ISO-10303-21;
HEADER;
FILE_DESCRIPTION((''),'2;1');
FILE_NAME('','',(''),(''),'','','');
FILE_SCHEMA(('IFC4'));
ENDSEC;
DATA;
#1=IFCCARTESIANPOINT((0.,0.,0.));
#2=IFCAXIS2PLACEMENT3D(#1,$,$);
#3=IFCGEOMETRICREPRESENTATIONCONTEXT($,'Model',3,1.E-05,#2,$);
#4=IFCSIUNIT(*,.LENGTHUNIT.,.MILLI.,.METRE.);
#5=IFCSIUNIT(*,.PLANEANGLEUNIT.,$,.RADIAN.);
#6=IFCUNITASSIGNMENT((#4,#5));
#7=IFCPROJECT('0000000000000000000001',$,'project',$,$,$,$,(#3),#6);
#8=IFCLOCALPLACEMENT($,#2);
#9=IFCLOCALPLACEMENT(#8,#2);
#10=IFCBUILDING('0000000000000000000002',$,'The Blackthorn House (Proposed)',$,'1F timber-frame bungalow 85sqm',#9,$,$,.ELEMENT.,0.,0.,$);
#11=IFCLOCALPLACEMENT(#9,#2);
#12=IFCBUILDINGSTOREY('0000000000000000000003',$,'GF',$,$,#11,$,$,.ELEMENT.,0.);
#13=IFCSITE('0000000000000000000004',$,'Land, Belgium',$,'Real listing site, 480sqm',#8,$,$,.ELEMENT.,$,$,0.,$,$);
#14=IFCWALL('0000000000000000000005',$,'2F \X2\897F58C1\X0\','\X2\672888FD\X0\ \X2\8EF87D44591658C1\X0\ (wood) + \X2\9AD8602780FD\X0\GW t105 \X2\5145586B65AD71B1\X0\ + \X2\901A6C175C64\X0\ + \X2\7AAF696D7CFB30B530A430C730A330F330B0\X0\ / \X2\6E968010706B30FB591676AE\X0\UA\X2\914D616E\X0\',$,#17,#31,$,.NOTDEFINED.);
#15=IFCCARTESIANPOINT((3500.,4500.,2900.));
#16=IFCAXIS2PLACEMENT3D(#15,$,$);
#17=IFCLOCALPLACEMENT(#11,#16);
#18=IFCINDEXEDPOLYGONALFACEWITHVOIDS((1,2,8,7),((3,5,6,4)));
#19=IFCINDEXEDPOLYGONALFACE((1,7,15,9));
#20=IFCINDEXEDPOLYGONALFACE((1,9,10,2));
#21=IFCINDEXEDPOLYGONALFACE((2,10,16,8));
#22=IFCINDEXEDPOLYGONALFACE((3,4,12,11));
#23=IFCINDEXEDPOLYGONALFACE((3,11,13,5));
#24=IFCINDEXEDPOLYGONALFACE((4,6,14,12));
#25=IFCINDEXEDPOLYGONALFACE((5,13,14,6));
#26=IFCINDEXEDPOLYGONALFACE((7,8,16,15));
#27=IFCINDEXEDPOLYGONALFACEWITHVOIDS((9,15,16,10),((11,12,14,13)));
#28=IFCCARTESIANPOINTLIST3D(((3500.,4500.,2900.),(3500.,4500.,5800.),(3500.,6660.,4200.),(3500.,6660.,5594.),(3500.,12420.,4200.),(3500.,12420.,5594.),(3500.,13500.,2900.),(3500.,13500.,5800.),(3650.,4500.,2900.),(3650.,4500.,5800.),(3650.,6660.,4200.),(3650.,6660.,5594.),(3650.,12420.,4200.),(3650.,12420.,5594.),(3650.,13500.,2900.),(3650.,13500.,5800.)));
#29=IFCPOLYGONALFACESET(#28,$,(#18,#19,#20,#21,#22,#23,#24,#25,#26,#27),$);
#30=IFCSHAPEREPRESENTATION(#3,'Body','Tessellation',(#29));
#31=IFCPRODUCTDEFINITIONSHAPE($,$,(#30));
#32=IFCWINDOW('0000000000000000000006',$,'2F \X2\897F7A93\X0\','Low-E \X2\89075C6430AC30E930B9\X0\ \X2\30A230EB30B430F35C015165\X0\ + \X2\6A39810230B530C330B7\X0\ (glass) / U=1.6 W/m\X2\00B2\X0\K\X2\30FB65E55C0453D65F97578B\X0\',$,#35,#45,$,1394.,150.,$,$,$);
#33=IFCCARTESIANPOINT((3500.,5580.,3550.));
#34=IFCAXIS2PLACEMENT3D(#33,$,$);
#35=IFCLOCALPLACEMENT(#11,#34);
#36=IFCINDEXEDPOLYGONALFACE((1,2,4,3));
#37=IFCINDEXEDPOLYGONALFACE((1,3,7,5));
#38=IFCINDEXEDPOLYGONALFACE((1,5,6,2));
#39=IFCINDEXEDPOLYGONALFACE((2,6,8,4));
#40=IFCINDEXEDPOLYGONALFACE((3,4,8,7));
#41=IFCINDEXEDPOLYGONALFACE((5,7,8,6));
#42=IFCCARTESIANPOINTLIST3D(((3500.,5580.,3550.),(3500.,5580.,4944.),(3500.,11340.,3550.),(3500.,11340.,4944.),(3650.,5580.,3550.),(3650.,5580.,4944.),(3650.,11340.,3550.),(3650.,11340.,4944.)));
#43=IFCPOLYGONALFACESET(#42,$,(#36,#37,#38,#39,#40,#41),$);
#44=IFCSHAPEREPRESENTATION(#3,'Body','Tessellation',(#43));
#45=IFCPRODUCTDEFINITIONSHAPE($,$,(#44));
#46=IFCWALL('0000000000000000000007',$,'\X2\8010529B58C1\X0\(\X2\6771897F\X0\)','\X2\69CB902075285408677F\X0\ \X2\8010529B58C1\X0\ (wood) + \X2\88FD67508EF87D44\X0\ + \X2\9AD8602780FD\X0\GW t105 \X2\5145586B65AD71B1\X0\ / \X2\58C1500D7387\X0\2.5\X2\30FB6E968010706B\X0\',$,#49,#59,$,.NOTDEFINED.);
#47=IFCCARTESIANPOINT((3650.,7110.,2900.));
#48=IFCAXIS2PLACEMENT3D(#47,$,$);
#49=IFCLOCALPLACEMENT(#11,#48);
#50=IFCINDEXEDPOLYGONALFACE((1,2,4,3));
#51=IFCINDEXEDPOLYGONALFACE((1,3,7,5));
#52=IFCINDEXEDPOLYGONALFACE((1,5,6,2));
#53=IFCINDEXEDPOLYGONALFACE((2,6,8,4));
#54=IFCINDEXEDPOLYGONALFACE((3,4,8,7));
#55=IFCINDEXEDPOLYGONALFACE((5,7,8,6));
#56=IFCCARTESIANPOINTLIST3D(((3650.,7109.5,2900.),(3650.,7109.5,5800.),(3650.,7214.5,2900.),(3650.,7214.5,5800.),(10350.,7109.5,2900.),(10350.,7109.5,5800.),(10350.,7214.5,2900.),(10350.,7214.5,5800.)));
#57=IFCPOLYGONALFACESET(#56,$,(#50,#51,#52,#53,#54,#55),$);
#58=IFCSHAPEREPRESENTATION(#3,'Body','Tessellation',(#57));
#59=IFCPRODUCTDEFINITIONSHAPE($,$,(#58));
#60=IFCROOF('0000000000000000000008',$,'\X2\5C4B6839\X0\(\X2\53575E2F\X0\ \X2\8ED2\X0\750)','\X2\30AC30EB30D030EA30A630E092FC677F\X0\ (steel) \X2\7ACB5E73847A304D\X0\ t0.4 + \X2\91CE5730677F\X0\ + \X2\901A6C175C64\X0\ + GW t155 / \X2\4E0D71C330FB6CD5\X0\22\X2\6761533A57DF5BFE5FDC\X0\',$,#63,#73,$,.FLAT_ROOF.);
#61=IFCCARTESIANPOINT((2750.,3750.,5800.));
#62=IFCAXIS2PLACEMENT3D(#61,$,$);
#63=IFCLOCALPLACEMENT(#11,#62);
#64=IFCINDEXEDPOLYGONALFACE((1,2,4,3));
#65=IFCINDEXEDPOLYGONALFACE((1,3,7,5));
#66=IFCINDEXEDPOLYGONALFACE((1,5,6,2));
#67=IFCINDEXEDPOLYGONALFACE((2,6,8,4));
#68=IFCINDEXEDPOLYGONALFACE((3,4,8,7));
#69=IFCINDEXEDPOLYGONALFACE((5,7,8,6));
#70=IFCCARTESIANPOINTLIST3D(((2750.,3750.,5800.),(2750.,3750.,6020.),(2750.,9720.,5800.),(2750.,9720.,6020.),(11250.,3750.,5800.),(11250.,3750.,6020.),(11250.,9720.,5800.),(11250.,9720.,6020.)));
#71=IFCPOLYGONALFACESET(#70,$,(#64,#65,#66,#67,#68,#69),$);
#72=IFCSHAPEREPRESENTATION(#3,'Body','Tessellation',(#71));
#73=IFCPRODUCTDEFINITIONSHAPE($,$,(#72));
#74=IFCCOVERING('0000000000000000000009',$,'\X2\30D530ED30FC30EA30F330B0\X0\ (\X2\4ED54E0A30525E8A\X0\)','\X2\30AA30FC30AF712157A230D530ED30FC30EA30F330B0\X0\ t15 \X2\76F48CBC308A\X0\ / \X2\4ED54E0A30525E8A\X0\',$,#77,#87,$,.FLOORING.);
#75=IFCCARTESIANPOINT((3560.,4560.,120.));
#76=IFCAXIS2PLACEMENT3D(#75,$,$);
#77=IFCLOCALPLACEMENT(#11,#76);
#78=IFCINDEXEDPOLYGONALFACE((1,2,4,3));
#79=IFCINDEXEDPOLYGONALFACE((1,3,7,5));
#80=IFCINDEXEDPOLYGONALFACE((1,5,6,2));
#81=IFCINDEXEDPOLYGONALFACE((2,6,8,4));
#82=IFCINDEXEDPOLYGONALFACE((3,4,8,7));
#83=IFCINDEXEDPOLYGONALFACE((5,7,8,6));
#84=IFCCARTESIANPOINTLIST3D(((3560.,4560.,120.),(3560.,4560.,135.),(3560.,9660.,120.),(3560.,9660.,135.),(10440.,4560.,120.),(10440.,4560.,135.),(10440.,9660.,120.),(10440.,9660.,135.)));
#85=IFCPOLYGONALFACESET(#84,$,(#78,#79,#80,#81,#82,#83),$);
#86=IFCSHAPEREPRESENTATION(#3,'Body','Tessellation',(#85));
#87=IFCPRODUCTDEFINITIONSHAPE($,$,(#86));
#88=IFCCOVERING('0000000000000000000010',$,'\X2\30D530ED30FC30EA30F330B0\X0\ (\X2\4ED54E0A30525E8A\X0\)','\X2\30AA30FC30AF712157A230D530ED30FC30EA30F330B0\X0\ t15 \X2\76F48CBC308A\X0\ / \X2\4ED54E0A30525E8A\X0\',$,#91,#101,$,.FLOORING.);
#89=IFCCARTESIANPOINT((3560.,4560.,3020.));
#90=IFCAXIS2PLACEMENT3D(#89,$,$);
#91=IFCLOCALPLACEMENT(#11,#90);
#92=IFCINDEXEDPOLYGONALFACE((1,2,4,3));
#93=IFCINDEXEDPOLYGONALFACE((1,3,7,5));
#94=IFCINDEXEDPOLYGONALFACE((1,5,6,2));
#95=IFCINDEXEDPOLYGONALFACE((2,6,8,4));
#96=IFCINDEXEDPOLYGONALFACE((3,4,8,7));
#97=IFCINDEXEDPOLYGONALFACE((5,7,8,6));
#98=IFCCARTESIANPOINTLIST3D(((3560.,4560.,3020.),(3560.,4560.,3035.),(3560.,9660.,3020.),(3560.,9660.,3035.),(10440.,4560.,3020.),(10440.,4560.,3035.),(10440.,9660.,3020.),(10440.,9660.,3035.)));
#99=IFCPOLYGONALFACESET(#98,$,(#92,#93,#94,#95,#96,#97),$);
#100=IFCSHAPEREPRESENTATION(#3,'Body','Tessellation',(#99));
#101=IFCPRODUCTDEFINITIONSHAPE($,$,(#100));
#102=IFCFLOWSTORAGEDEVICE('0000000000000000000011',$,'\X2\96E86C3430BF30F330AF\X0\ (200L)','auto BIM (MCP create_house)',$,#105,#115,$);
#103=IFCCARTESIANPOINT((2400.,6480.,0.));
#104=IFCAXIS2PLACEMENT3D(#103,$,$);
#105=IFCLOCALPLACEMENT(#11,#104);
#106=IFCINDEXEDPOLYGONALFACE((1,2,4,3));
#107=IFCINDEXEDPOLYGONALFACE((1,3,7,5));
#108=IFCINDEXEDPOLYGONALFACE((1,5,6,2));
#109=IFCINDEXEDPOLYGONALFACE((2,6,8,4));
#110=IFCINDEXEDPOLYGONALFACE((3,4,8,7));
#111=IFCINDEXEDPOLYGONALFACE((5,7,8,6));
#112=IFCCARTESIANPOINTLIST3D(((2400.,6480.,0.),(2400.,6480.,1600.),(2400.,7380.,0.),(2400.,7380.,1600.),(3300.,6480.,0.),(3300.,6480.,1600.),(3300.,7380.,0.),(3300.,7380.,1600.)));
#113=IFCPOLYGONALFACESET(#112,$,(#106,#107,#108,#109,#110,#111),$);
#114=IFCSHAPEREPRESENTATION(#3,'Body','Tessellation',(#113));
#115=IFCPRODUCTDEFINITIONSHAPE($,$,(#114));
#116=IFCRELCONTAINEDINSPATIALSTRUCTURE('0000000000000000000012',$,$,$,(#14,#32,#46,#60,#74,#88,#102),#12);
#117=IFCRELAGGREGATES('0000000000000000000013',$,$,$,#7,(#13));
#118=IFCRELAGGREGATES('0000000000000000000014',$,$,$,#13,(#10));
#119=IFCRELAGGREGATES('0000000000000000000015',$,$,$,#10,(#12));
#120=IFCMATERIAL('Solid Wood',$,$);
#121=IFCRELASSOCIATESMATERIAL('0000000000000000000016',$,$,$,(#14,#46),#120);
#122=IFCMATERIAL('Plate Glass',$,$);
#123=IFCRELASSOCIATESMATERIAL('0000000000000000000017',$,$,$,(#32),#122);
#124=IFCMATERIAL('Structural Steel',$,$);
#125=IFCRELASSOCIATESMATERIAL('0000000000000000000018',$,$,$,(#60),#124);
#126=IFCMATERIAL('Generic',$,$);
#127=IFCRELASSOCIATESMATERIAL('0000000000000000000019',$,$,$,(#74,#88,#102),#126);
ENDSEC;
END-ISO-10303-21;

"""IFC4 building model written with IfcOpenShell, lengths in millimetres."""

from ifc_helpers import new_model, si_unit, frame, frame_2d, origin, place, context, project, spatial, rectangle, extrude, material, element, fill, save


model = new_model("IFC4")

# Units and contexts
model_context = context("Model", 3, precision=1e-05, world=origin())
ifc_project = project(units=[si_unit("LENGTHUNIT", "METRE", prefix="MILLI"), si_unit("PLANEANGLEUNIT", "RADIAN")], contexts=[model_context])

# Site, building, storey
site_placement = place(None, origin())
site = spatial("IfcSite", under=ifc_project, at=site_placement, Name="Land, Belgium", ObjectType="Real listing site, 480sqm", CompositionType="ELEMENT", RefElevation=0.0)
building_placement = place(site_placement, origin())
building = spatial("IfcBuilding", under=site, at=building_placement, Name="The Blackthorn House (Proposed)", ObjectType="1F timber-frame bungalow 85sqm", CompositionType="ELEMENT", ElevationOfRefHeight=0.0, ElevationOfTerrain=0.0)
storey_placement = place(building_placement, origin())
storey = spatial("IfcBuildingStorey", under=building, at=storey_placement, Name="GF", CompositionType="ELEMENT", Elevation=0.0)

# Shared definitions
ifc_material_1 = material(Name="Solid Wood")
ifc_material_2 = material(Name="Generic")

# Shared definitions
ifc_material_3 = material(Name="Plate Glass")

# Wall, opening, window
wall_1_placement = place(storey_placement, frame((3500.0, 4500.0, 2900.0)))
wall_1 = element("IfcWall", 1, at=wall_1_placement, inside=storey, material=ifc_material_1, Name="2F 西壁", Description="木製 軸組外壁 (wood) + 高性能GW t105 充填断熱 + 通気層 + 窯業系サイディング / 準耐火・外皮UA配慮", PredefinedType="NOTDEFINED", context=model_context, shape_type="SweptSolid", body=[
    extrude(rectangle(XDim=150.0, YDim=9000.0, at=frame_2d((75.0, 4500.0))), frame((3500.0, 4500.0, 2900.0)), (0.0, 0.0, 1.0), 2900.0),
])
opening_1_placement = place(storey_placement, frame((3500.0, 5580.0, 3550.0)))
opening_1 = element("IfcOpeningElement", 2, at=opening_1_placement, cuts=wall_1, PredefinedType="NOTDEFINED", context=model_context, shape_type="SweptSolid", body=[
    extrude(rectangle(XDim=150.0, YDim=5760.0, at=frame_2d((75.0, 2880.0))), frame((3500.0, 5580.0, 3550.0)), (0.0, 0.0, 1.0), 1394.0),
])
window_1_placement = place(storey_placement, frame((3500.0, 5580.0, 3550.0)))
window_1 = element("IfcWindow", 3, at=window_1_placement, inside=storey, material=ifc_material_3, Name="2F 西窓", Description="Low-E 複層ガラス アルゴン封入 + 樹脂サッシ (glass) / U=1.6 W/m²K・日射取得型", OverallHeight=1394.0, OverallWidth=150.0, context=model_context, shape_type="SweptSolid", body=[
    extrude(rectangle(XDim=150.0, YDim=5760.0, at=frame_2d((75.0, 2880.0))), frame((3500.0, 5580.0, 3550.0)), (0.0, 0.0, 1.0), 1394.0),
])
fill(opening_1, window_1)

# Wall
wall_2_placement = place(storey_placement, frame((3650.0, 7110.0, 2900.0)))
element("IfcWall", 4, at=wall_2_placement, inside=storey, material=ifc_material_1, Name="耐力壁(東西)", Description="構造用合板 耐力壁 (wood) + 製材軸組 + 高性能GW t105 充填断熱 / 壁倍率2.5・準耐火", PredefinedType="NOTDEFINED", context=model_context, shape_type="SweptSolid", body=[
    extrude(rectangle(XDim=6700.0, YDim=105.0, at=frame_2d((3350.0, 52.0))), frame((3650.0, 7110.0, 2900.0)), (0.0, 0.0, 1.0), 2900.0),
])

# Roof
ifc_material_4 = material(Name="Structural Steel")
for number, where, name in (
    (5, (2750.0, 3750.0, 5800.0), "屋根(南帯 軒750)"),
):
    element("IfcRoof", number, at=place(storey_placement, frame(where)), inside=storey, material=ifc_material_4, Name=name, Description="ガルバリウム鋼板 (steel) 立平葺き t0.4 + 野地板 + 通気層 + GW t155 / 不燃・法22条区域対応", PredefinedType="FLAT_ROOF", context=model_context, shape_type="SweptSolid", body=[
        extrude(rectangle(XDim=8500.0, YDim=5970.0, at=frame_2d((4250.0, 2985.0))), frame((2750.0, 3750.0, 5800.0)), (0.0, 0.0, 1.0), 220.0),
    ])

# Coverings
covering_1_placement = place(storey_placement, frame((3560.0, 4560.0, 120.0)))
element("IfcCovering", 6, at=covering_1_placement, inside=storey, material=ifc_material_2, Name="フローリング (仕上げ床)", Description="オーク無垢フローリング t15 直貼り / 仕上げ床", PredefinedType="FLOORING", context=model_context, shape_type="SweptSolid", body=[
    extrude(rectangle(XDim=6880.0, YDim=5100.0, at=frame_2d((3440.0, 2550.0))), frame((3560.0, 4560.0, 120.0)), (0.0, 0.0, 1.0), 15.0),
])
covering_2_placement = place(storey_placement, frame((3560.0, 4560.0, 3020.0)))
element("IfcCovering", 7, at=covering_2_placement, inside=storey, material=ifc_material_2, Name="フローリング (仕上げ床)", Description="オーク無垢フローリング t15 直貼り / 仕上げ床", PredefinedType="FLOORING", context=model_context, shape_type="SweptSolid", body=[
    extrude(rectangle(XDim=6880.0, YDim=5100.0, at=frame_2d((3440.0, 2550.0))), frame((3560.0, 4560.0, 3020.0)), (0.0, 0.0, 1.0), 15.0),
])

# Flow storage device
flow_storage_device_placement = place(storey_placement, frame((2400.0, 6480.0, 0.0)))
element("IfcFlowStorageDevice", 8, at=flow_storage_device_placement, inside=storey, material=ifc_material_2, Name="雨水タンク (200L)", Description="auto BIM (MCP create_house)", context=model_context, shape_type="SweptSolid", body=[
    extrude(rectangle(XDim=900.0, YDim=900.0, at=frame_2d((450.0, 450.0))), frame((2400.0, 6480.0, 0.0)), (0.0, 0.0, 1.0), 1600.0),
])

save(model, "model.ifc")
